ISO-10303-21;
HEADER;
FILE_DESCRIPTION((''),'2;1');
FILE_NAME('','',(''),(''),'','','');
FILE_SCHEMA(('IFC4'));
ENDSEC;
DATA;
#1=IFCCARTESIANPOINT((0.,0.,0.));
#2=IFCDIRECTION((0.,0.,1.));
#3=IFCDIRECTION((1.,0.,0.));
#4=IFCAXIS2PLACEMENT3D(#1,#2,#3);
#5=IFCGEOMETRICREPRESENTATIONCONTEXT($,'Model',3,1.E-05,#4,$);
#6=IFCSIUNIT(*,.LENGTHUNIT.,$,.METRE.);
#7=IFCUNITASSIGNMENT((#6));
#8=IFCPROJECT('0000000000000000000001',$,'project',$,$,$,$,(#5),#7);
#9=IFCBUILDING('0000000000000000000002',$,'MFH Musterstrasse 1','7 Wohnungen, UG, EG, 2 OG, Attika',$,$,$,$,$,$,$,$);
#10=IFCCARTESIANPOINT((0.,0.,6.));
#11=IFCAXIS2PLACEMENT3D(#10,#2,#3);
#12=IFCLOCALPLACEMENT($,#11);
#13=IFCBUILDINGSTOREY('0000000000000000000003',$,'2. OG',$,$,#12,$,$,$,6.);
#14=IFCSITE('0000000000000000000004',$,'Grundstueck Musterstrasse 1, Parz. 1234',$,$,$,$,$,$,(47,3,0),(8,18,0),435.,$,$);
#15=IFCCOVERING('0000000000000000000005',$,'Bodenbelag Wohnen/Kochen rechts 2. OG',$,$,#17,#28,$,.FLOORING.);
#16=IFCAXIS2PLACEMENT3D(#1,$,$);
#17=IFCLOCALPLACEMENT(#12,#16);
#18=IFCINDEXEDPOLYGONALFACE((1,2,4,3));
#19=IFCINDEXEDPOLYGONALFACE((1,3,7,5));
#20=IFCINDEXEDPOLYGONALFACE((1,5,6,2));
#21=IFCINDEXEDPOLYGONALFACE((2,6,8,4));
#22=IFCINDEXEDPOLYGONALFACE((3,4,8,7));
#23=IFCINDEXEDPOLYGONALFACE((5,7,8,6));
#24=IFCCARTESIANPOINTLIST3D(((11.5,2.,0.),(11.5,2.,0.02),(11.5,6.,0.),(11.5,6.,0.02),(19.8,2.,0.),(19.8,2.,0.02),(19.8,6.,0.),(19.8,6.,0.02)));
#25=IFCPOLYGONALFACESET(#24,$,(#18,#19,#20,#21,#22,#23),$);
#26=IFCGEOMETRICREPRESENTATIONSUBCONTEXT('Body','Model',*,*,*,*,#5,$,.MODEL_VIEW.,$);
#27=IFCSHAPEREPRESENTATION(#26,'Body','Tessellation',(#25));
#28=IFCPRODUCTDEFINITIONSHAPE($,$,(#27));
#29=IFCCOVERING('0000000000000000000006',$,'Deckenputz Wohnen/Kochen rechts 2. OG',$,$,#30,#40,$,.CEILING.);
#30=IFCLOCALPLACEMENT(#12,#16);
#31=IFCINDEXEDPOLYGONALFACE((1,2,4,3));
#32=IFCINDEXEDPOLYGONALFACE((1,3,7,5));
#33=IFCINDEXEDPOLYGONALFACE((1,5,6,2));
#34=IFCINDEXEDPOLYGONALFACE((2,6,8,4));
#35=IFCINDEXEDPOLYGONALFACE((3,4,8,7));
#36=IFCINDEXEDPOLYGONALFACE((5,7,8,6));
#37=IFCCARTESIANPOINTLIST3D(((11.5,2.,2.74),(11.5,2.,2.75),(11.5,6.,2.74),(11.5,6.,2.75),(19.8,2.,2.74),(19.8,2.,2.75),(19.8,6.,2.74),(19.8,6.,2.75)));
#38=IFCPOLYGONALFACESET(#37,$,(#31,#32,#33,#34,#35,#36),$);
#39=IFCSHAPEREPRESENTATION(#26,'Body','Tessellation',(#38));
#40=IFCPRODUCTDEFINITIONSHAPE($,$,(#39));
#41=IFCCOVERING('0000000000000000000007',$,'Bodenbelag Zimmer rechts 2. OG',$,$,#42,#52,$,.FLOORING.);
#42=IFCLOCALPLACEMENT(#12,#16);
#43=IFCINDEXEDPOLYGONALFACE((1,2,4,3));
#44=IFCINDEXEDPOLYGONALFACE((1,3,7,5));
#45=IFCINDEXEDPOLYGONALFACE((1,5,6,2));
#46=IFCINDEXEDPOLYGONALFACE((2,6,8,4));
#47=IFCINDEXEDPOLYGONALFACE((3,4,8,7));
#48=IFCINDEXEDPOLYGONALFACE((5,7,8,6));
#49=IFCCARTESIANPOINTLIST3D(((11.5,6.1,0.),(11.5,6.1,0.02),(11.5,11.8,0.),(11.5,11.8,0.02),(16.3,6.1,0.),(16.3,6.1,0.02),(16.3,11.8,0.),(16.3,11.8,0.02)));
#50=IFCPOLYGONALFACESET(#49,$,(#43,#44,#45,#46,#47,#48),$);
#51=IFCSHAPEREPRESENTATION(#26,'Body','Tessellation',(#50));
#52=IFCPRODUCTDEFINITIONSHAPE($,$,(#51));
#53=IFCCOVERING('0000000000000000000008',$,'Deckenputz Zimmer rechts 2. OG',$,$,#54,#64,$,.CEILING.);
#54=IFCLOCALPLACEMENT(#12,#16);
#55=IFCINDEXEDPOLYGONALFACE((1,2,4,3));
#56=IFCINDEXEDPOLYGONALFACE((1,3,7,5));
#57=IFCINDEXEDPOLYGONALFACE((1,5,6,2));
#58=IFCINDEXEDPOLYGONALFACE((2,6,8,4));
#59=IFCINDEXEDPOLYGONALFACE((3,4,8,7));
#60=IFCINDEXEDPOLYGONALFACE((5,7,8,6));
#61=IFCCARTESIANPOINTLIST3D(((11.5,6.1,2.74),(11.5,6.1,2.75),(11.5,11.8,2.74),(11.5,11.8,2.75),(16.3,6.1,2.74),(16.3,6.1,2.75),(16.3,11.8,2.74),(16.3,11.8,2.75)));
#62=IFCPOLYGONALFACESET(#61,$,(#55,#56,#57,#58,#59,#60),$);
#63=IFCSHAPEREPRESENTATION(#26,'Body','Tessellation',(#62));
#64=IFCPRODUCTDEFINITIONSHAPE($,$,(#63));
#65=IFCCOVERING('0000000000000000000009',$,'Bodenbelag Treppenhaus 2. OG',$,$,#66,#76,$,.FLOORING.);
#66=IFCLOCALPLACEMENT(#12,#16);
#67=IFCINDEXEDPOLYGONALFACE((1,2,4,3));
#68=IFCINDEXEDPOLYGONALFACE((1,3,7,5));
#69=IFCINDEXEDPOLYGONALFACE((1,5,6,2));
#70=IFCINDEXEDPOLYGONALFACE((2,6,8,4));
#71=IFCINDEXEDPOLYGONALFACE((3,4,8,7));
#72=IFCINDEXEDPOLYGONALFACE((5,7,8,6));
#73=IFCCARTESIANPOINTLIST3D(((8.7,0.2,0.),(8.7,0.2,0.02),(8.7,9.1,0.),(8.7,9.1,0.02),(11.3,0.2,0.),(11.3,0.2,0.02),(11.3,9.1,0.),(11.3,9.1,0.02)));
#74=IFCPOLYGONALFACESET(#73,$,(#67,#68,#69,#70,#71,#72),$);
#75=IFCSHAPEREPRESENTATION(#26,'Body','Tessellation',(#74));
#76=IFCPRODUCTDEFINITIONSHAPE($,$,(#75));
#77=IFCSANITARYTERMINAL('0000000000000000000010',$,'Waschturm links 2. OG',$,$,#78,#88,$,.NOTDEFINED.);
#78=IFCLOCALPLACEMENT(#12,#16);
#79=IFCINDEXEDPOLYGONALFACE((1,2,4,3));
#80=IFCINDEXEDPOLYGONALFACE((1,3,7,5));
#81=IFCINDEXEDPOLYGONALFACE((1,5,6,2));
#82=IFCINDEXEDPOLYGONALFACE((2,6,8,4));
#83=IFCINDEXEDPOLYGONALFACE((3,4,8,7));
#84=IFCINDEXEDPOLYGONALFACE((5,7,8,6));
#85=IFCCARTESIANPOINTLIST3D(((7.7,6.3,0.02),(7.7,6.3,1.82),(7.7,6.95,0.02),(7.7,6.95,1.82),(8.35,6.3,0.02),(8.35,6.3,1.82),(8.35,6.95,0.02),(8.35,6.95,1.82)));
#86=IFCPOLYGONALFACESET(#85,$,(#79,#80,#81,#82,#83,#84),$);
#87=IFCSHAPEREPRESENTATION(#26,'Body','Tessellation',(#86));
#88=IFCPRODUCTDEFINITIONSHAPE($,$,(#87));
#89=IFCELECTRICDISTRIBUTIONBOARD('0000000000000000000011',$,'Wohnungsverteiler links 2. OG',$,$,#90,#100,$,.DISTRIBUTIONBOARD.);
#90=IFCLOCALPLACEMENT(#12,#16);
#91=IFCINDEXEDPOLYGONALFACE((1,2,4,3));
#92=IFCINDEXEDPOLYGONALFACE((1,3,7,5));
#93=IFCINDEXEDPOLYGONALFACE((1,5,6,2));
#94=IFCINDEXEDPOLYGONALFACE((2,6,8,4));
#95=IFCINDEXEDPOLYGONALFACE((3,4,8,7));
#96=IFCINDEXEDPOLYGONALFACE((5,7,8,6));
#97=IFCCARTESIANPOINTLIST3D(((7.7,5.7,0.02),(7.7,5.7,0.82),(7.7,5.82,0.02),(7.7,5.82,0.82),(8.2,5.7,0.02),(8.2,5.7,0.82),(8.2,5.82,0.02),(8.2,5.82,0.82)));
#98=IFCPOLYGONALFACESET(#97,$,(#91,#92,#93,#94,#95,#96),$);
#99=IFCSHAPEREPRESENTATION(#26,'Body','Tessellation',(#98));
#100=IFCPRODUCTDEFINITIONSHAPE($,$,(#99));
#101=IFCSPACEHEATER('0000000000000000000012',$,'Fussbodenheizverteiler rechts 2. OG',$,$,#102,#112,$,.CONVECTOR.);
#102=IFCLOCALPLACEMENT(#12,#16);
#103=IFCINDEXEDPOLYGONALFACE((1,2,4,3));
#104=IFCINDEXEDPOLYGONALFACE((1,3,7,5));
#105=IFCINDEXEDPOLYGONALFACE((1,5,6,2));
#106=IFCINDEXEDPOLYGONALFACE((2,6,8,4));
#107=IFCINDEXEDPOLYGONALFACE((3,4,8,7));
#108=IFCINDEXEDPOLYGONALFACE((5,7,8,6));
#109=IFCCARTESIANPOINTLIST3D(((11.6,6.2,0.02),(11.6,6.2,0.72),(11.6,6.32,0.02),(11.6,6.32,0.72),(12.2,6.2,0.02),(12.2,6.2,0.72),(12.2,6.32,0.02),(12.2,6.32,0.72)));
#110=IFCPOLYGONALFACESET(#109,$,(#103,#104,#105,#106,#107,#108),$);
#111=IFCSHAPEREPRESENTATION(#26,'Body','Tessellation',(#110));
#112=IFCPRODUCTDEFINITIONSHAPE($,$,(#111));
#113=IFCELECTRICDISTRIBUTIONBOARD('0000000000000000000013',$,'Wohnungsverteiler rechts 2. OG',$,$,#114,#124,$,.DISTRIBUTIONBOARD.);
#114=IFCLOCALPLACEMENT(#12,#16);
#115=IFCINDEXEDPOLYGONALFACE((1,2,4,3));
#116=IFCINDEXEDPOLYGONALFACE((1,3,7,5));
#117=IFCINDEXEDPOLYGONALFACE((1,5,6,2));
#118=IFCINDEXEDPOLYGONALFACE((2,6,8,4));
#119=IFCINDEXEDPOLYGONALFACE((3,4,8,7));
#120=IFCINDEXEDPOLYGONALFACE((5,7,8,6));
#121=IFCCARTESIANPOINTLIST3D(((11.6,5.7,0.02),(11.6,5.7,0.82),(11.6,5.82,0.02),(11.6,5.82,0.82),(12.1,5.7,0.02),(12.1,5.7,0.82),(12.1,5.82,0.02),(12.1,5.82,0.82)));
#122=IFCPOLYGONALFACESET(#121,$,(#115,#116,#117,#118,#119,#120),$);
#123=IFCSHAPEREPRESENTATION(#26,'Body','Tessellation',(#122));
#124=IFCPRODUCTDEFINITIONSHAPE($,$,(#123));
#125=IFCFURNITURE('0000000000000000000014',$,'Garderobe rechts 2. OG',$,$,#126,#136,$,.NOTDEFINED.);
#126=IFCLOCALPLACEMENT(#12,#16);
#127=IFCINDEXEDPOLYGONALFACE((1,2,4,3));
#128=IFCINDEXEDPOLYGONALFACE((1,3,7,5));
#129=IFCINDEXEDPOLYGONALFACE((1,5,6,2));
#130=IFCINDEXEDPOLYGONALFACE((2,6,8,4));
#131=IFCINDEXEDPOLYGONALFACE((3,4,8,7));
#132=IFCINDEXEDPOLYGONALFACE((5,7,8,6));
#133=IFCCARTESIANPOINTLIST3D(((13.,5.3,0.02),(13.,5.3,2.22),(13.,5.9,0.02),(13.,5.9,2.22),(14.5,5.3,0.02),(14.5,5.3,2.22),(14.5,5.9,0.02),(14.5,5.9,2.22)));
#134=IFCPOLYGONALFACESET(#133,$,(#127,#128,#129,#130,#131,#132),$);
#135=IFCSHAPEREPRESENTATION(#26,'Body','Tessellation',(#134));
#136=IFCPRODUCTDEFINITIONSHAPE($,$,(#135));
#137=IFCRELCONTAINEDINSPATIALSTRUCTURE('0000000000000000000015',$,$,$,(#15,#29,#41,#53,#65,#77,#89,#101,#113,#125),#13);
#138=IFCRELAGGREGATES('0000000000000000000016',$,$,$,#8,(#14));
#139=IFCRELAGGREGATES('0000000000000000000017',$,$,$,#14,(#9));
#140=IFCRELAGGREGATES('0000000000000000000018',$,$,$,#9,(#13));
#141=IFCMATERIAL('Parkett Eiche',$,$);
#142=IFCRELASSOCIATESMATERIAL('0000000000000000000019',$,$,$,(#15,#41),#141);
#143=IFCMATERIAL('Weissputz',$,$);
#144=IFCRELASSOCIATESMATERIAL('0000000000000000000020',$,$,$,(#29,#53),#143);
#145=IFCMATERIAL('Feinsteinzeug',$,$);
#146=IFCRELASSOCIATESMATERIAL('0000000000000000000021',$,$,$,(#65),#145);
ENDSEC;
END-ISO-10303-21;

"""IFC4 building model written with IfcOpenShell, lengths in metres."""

from ifc_helpers import new_model, si_unit, frame, frame_2d, origin_with_axes, place, context, subcontext, project, spatial, rectangle, extrude, material, element, save


model = new_model("IFC4")

# Units and contexts
model_context = context("Model", 3, precision=1e-05, world=origin_with_axes())
body_context = subcontext(model_context, "Body", "Model", "MODEL_VIEW")
ifc_project = project(units=[si_unit("LENGTHUNIT", "METRE")], contexts=[model_context])

# Site, building, storey
site = spatial("IfcSite", under=ifc_project, Name="Grundstueck Musterstrasse 1, Parz. 1234", RefLatitude=(47, 3, 0), RefLongitude=(8, 18, 0), RefElevation=435.0)
building = spatial("IfcBuilding", under=site, Name="MFH Musterstrasse 1", Description="7 Wohnungen, UG, EG, 2 OG, Attika")
storey_placement = place(None, frame((0.0, 0.0, 6.0), z_axis=(0.0, 0.0, 1.0), x_axis=(1.0, 0.0, 0.0)))
storey = spatial("IfcBuildingStorey", under=building, at=storey_placement, Name="2. OG", Elevation=6.0)

# Coverings
ifc_material_1 = material(Name="Parkett Eiche")
covering_1_placement = place(storey_placement, frame((11.5, 2.0, 0.0), z_axis=(0.0, 0.0, 1.0), x_axis=(1.0, 0.0, 0.0)))
element("IfcCovering", 1, at=covering_1_placement, inside=storey, material=ifc_material_1, Name="Bodenbelag Wohnen/Kochen rechts 2. OG", PredefinedType="FLOORING", context=body_context, shape_type="SweptSolid", body=[
    extrude(rectangle(XDim=8.3, YDim=4.0, at=frame_2d((4.15, 2.0))), origin_with_axes(), (0.0, 0.0, 1.0), 0.02),
])
ifc_material_2 = material(Name="Weissputz")
covering_2_placement = place(storey_placement, frame((11.5, 2.0, 2.74), z_axis=(0.0, 0.0, 1.0), x_axis=(1.0, 0.0, 0.0)))
element("IfcCovering", 2, at=covering_2_placement, inside=storey, material=ifc_material_2, Name="Deckenputz Wohnen/Kochen rechts 2. OG", PredefinedType="CEILING", context=body_context, shape_type="SweptSolid", body=[
    extrude(rectangle(XDim=8.3, YDim=4.0, at=frame_2d((4.15, 2.0))), origin_with_axes(), (0.0, 0.0, 1.0), 0.01),
])
covering_3_placement = place(storey_placement, frame((11.5, 6.1, 0.0), z_axis=(0.0, 0.0, 1.0), x_axis=(1.0, 0.0, 0.0)))
element("IfcCovering", 3, at=covering_3_placement, inside=storey, material=ifc_material_1, Name="Bodenbelag Zimmer rechts 2. OG", PredefinedType="FLOORING", context=body_context, shape_type="SweptSolid", body=[
    extrude(rectangle(XDim=4.8, YDim=5.7, at=frame_2d((2.4, 2.85))), origin_with_axes(), (0.0, 0.0, 1.0), 0.02),
])
covering_4_placement = place(storey_placement, frame((11.5, 6.1, 2.74), z_axis=(0.0, 0.0, 1.0), x_axis=(1.0, 0.0, 0.0)))
element("IfcCovering", 4, at=covering_4_placement, inside=storey, material=ifc_material_2, Name="Deckenputz Zimmer rechts 2. OG", PredefinedType="CEILING", context=body_context, shape_type="SweptSolid", body=[
    extrude(rectangle(XDim=4.8, YDim=5.7, at=frame_2d((2.4, 2.85))), origin_with_axes(), (0.0, 0.0, 1.0), 0.01),
])
ifc_material_3 = material(Name="Feinsteinzeug")
covering_5_placement = place(storey_placement, frame((8.7, 0.2, 0.0), z_axis=(0.0, 0.0, 1.0), x_axis=(1.0, 0.0, 0.0)))
element("IfcCovering", 5, at=covering_5_placement, inside=storey, material=ifc_material_3, Name="Bodenbelag Treppenhaus 2. OG", PredefinedType="FLOORING", context=body_context, shape_type="SweptSolid", body=[
    extrude(rectangle(XDim=2.6, YDim=8.9, at=frame_2d((1.3, 4.45))), origin_with_axes(), (0.0, 0.0, 1.0), 0.02),
])

# Sanitary terminal
sanitary_terminal_placement = place(storey_placement, frame((7.7, 6.3, 0.02), z_axis=(0.0, 0.0, 1.0), x_axis=(1.0, 0.0, 0.0)))
element("IfcSanitaryTerminal", 6, at=sanitary_terminal_placement, inside=storey, Name="Waschturm links 2. OG", PredefinedType="NOTDEFINED", context=body_context, shape_type="SweptSolid", body=[
    extrude(rectangle(XDim=0.65, YDim=0.65, at=frame_2d((0.325, 0.325))), origin_with_axes(), (0.0, 0.0, 1.0), 1.8),
])

# Electric distribution board
electric_distribution_board_1_placement = place(storey_placement, frame((7.7, 5.7, 0.02), z_axis=(0.0, 0.0, 1.0), x_axis=(1.0, 0.0, 0.0)))
element("IfcElectricDistributionBoard", 7, at=electric_distribution_board_1_placement, inside=storey, Name="Wohnungsverteiler links 2. OG", PredefinedType="DISTRIBUTIONBOARD", context=body_context, shape_type="SweptSolid", body=[
    extrude(rectangle(XDim=0.5, YDim=0.12, at=frame_2d((0.25, 0.06))), origin_with_axes(), (0.0, 0.0, 1.0), 0.8),
])

# Space heater
space_heater_placement = place(storey_placement, frame((11.6, 6.2, 0.02), z_axis=(0.0, 0.0, 1.0), x_axis=(1.0, 0.0, 0.0)))
element("IfcSpaceHeater", 8, at=space_heater_placement, inside=storey, Name="Fussbodenheizverteiler rechts 2. OG", PredefinedType="CONVECTOR", context=body_context, shape_type="SweptSolid", body=[
    extrude(rectangle(XDim=0.6, YDim=0.12, at=frame_2d((0.3, 0.06))), origin_with_axes(), (0.0, 0.0, 1.0), 0.7),
])

# Electric distribution board
electric_distribution_board_2_placement = place(storey_placement, frame((11.6, 5.7, 0.02), z_axis=(0.0, 0.0, 1.0), x_axis=(1.0, 0.0, 0.0)))
element("IfcElectricDistributionBoard", 9, at=electric_distribution_board_2_placement, inside=storey, Name="Wohnungsverteiler rechts 2. OG", PredefinedType="DISTRIBUTIONBOARD", context=body_context, shape_type="SweptSolid", body=[
    extrude(rectangle(XDim=0.5, YDim=0.12, at=frame_2d((0.25, 0.06))), origin_with_axes(), (0.0, 0.0, 1.0), 0.8),
])

# Furniture
furniture_placement = place(storey_placement, frame((13.0, 5.3, 0.02), z_axis=(0.0, 0.0, 1.0), x_axis=(1.0, 0.0, 0.0)))
element("IfcFurniture", 10, at=furniture_placement, inside=storey, Name="Garderobe rechts 2. OG", PredefinedType="NOTDEFINED", context=body_context, shape_type="SweptSolid", body=[
    extrude(rectangle(XDim=1.5, YDim=0.6, at=frame_2d((0.75, 0.3))), origin_with_axes(), (0.0, 0.0, 1.0), 2.2),
])

save(model, "model.ifc")
